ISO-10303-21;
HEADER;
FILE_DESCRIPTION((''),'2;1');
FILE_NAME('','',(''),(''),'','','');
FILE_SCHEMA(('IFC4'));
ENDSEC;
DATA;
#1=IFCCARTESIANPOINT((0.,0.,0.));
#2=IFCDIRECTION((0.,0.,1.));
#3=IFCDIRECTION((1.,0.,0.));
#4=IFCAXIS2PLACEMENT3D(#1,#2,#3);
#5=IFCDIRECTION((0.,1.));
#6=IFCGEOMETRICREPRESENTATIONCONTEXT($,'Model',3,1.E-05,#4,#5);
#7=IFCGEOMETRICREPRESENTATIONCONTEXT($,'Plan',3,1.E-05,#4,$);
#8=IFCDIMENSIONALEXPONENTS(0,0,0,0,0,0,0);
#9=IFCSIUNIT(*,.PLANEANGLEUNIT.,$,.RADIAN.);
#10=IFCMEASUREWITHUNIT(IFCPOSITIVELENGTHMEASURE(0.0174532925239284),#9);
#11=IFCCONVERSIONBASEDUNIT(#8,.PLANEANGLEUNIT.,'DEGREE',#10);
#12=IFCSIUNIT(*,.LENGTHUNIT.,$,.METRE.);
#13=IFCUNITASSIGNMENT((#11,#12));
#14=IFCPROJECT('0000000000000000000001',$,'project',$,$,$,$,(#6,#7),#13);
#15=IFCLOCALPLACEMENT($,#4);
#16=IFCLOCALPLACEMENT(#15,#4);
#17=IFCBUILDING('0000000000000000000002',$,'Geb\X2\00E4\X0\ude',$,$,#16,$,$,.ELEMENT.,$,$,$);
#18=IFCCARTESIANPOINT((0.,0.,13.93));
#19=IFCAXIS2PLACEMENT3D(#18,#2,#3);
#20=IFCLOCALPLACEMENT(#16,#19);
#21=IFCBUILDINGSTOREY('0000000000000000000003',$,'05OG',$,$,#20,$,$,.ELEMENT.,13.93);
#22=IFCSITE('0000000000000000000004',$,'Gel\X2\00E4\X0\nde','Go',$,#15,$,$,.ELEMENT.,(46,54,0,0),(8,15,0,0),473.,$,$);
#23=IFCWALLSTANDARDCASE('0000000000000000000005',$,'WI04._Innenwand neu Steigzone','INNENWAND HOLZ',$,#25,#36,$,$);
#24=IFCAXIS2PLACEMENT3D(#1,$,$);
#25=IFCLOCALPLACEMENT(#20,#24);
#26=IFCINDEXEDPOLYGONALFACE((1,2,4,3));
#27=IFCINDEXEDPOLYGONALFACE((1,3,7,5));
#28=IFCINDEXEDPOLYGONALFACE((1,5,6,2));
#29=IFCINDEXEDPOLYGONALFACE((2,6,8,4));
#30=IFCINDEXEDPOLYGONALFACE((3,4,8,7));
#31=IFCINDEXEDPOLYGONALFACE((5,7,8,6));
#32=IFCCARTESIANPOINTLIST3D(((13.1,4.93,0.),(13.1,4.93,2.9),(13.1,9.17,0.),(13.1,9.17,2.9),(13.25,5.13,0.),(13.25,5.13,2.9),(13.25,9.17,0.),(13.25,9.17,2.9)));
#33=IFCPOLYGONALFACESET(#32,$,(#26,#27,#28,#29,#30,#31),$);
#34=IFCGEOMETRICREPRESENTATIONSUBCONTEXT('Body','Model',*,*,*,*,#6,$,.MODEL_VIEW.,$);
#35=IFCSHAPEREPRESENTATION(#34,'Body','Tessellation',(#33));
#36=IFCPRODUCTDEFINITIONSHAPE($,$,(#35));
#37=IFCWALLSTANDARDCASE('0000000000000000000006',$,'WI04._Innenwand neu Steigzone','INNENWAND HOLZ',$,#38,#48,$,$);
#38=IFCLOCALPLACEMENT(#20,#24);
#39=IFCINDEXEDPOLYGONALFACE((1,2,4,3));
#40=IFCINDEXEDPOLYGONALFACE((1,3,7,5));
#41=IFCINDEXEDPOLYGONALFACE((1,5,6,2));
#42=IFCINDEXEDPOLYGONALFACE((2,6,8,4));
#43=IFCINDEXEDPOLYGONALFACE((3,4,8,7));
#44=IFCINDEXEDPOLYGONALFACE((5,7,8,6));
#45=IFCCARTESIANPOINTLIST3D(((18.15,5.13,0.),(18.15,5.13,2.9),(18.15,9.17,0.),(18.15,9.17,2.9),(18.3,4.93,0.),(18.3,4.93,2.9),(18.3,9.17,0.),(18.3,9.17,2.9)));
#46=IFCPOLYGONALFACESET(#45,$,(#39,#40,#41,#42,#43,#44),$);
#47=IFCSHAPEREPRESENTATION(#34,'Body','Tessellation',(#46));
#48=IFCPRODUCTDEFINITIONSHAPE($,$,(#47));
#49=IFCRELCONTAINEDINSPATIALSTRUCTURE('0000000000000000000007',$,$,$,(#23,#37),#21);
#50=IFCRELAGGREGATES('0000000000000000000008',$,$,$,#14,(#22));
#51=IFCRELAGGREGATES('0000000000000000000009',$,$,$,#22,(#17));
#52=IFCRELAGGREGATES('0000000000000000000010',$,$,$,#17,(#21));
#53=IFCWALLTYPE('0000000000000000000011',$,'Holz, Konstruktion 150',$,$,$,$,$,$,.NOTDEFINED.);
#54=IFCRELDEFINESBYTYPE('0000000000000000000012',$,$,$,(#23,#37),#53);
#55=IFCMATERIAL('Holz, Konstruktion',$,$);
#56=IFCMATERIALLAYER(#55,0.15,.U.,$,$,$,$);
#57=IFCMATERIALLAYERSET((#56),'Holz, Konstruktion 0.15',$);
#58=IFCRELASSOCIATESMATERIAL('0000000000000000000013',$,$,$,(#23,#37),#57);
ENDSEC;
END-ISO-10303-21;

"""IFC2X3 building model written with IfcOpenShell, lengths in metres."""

from ifc_helpers import new_model, entity, si_unit, converted_unit, direction, frame, origin_with_axes, place, context, subcontext, project, spatial, polyline, outline, extrude, material, layer, layer_set, layer_usage, type_object, element, save


model = new_model("IFC2X3")

# Units and contexts
model_context = context("Model", 3, precision=1e-05, world=origin_with_axes(), true_north=direction((0.0, 1.0)))
plan_context = context("Plan", 3, precision=1e-05, world=origin_with_axes())
body_context = subcontext(model_context, "Body", "Model", "MODEL_VIEW")
ifc_project = project(units=[converted_unit("PLANEANGLEUNIT", "DEGREE", entity("IfcPositiveLengthMeasure", 0.0174532925239284), si_unit("PLANEANGLEUNIT", "RADIAN"), dimensions=[0, 0, 0, 0, 0, 0, 0]), si_unit("LENGTHUNIT", "METRE")], contexts=[model_context, plan_context])

# Site, building, storey
site_placement = place(None, origin_with_axes())
site = spatial("IfcSite", under=ifc_project, at=site_placement, Name="Gelände", Description="Go", CompositionType="ELEMENT", RefLatitude=(46, 54, 0, 0), RefLongitude=(8, 15, 0, 0), RefElevation=473.0)
building_placement = place(site_placement, origin_with_axes())
building = spatial("IfcBuilding", under=site, at=building_placement, Name="Gebäude", CompositionType="ELEMENT")
storey_placement = place(building_placement, frame((0.0, 0.0, 13.93), z_axis=(0.0, 0.0, 1.0), x_axis=(1.0, 0.0, 0.0)))
storey = spatial("IfcBuildingStorey", under=building, at=storey_placement, Name="05OG", CompositionType="ELEMENT", Elevation=13.93)

# Shared definitions
ifc_material_1 = material(Name="Holz, Konstruktion")

# Walls
ifc_layer_1 = layer(ifc_material_1, 0.15, ventilated="UNKNOWN")
ifc_layer_set_1 = layer_set([ifc_layer_1], Name="Holz, Konstruktion 0.15")
wall_type_1 = type_object("IfcWallType", Name="Holz, Konstruktion 150", PredefinedType="NOTDEFINED")
ifc_layer_usage_1 = layer_usage(ifc_layer_set_1, "AXIS2", "POSITIVE", 0.0)
wall_1_placement = place(storey_placement, frame((13.1, 9.17, 0.0), z_axis=(0.0, 0.0, 1.0), x_axis=(0.0, -1.0, 0.0)))
element("IfcWallStandardCase", 1, at=wall_1_placement, inside=storey, type_object=wall_type_1, material=ifc_layer_usage_1, Name="WI04._Innenwand neu Steigzone", Description="INNENWAND HOLZ", context=body_context, shape_type="SweptSolid", body=[
    extrude(outline(polyline([(0.0, 0.0), (4.24, 0.0), (4.04, 0.15), (0.0, 0.15), (0.0, 0.0)])), origin_with_axes(), (0.0, 0.0, 1.0), 2.9),
])
ifc_layer_usage_2 = layer_usage(ifc_layer_set_1, "AXIS2", "NEGATIVE", 0.0)
wall_2_placement = place(storey_placement, frame((18.3, 9.17, 0.0), z_axis=(0.0, 0.0, 1.0), x_axis=(0.0, -1.0, 0.0)))
element("IfcWallStandardCase", 2, at=wall_2_placement, inside=storey, type_object=wall_type_1, material=ifc_layer_usage_2, Name="WI04._Innenwand neu Steigzone", Description="INNENWAND HOLZ", context=body_context, shape_type="SweptSolid", body=[
    extrude(outline(polyline([(0.0, -0.15), (4.04, -0.15), (4.24, 0.0), (0.0, 0.0), (0.0, -0.15)])), origin_with_axes(), (0.0, 0.0, 1.0), 2.9),
])

save(model, "model.ifc")
